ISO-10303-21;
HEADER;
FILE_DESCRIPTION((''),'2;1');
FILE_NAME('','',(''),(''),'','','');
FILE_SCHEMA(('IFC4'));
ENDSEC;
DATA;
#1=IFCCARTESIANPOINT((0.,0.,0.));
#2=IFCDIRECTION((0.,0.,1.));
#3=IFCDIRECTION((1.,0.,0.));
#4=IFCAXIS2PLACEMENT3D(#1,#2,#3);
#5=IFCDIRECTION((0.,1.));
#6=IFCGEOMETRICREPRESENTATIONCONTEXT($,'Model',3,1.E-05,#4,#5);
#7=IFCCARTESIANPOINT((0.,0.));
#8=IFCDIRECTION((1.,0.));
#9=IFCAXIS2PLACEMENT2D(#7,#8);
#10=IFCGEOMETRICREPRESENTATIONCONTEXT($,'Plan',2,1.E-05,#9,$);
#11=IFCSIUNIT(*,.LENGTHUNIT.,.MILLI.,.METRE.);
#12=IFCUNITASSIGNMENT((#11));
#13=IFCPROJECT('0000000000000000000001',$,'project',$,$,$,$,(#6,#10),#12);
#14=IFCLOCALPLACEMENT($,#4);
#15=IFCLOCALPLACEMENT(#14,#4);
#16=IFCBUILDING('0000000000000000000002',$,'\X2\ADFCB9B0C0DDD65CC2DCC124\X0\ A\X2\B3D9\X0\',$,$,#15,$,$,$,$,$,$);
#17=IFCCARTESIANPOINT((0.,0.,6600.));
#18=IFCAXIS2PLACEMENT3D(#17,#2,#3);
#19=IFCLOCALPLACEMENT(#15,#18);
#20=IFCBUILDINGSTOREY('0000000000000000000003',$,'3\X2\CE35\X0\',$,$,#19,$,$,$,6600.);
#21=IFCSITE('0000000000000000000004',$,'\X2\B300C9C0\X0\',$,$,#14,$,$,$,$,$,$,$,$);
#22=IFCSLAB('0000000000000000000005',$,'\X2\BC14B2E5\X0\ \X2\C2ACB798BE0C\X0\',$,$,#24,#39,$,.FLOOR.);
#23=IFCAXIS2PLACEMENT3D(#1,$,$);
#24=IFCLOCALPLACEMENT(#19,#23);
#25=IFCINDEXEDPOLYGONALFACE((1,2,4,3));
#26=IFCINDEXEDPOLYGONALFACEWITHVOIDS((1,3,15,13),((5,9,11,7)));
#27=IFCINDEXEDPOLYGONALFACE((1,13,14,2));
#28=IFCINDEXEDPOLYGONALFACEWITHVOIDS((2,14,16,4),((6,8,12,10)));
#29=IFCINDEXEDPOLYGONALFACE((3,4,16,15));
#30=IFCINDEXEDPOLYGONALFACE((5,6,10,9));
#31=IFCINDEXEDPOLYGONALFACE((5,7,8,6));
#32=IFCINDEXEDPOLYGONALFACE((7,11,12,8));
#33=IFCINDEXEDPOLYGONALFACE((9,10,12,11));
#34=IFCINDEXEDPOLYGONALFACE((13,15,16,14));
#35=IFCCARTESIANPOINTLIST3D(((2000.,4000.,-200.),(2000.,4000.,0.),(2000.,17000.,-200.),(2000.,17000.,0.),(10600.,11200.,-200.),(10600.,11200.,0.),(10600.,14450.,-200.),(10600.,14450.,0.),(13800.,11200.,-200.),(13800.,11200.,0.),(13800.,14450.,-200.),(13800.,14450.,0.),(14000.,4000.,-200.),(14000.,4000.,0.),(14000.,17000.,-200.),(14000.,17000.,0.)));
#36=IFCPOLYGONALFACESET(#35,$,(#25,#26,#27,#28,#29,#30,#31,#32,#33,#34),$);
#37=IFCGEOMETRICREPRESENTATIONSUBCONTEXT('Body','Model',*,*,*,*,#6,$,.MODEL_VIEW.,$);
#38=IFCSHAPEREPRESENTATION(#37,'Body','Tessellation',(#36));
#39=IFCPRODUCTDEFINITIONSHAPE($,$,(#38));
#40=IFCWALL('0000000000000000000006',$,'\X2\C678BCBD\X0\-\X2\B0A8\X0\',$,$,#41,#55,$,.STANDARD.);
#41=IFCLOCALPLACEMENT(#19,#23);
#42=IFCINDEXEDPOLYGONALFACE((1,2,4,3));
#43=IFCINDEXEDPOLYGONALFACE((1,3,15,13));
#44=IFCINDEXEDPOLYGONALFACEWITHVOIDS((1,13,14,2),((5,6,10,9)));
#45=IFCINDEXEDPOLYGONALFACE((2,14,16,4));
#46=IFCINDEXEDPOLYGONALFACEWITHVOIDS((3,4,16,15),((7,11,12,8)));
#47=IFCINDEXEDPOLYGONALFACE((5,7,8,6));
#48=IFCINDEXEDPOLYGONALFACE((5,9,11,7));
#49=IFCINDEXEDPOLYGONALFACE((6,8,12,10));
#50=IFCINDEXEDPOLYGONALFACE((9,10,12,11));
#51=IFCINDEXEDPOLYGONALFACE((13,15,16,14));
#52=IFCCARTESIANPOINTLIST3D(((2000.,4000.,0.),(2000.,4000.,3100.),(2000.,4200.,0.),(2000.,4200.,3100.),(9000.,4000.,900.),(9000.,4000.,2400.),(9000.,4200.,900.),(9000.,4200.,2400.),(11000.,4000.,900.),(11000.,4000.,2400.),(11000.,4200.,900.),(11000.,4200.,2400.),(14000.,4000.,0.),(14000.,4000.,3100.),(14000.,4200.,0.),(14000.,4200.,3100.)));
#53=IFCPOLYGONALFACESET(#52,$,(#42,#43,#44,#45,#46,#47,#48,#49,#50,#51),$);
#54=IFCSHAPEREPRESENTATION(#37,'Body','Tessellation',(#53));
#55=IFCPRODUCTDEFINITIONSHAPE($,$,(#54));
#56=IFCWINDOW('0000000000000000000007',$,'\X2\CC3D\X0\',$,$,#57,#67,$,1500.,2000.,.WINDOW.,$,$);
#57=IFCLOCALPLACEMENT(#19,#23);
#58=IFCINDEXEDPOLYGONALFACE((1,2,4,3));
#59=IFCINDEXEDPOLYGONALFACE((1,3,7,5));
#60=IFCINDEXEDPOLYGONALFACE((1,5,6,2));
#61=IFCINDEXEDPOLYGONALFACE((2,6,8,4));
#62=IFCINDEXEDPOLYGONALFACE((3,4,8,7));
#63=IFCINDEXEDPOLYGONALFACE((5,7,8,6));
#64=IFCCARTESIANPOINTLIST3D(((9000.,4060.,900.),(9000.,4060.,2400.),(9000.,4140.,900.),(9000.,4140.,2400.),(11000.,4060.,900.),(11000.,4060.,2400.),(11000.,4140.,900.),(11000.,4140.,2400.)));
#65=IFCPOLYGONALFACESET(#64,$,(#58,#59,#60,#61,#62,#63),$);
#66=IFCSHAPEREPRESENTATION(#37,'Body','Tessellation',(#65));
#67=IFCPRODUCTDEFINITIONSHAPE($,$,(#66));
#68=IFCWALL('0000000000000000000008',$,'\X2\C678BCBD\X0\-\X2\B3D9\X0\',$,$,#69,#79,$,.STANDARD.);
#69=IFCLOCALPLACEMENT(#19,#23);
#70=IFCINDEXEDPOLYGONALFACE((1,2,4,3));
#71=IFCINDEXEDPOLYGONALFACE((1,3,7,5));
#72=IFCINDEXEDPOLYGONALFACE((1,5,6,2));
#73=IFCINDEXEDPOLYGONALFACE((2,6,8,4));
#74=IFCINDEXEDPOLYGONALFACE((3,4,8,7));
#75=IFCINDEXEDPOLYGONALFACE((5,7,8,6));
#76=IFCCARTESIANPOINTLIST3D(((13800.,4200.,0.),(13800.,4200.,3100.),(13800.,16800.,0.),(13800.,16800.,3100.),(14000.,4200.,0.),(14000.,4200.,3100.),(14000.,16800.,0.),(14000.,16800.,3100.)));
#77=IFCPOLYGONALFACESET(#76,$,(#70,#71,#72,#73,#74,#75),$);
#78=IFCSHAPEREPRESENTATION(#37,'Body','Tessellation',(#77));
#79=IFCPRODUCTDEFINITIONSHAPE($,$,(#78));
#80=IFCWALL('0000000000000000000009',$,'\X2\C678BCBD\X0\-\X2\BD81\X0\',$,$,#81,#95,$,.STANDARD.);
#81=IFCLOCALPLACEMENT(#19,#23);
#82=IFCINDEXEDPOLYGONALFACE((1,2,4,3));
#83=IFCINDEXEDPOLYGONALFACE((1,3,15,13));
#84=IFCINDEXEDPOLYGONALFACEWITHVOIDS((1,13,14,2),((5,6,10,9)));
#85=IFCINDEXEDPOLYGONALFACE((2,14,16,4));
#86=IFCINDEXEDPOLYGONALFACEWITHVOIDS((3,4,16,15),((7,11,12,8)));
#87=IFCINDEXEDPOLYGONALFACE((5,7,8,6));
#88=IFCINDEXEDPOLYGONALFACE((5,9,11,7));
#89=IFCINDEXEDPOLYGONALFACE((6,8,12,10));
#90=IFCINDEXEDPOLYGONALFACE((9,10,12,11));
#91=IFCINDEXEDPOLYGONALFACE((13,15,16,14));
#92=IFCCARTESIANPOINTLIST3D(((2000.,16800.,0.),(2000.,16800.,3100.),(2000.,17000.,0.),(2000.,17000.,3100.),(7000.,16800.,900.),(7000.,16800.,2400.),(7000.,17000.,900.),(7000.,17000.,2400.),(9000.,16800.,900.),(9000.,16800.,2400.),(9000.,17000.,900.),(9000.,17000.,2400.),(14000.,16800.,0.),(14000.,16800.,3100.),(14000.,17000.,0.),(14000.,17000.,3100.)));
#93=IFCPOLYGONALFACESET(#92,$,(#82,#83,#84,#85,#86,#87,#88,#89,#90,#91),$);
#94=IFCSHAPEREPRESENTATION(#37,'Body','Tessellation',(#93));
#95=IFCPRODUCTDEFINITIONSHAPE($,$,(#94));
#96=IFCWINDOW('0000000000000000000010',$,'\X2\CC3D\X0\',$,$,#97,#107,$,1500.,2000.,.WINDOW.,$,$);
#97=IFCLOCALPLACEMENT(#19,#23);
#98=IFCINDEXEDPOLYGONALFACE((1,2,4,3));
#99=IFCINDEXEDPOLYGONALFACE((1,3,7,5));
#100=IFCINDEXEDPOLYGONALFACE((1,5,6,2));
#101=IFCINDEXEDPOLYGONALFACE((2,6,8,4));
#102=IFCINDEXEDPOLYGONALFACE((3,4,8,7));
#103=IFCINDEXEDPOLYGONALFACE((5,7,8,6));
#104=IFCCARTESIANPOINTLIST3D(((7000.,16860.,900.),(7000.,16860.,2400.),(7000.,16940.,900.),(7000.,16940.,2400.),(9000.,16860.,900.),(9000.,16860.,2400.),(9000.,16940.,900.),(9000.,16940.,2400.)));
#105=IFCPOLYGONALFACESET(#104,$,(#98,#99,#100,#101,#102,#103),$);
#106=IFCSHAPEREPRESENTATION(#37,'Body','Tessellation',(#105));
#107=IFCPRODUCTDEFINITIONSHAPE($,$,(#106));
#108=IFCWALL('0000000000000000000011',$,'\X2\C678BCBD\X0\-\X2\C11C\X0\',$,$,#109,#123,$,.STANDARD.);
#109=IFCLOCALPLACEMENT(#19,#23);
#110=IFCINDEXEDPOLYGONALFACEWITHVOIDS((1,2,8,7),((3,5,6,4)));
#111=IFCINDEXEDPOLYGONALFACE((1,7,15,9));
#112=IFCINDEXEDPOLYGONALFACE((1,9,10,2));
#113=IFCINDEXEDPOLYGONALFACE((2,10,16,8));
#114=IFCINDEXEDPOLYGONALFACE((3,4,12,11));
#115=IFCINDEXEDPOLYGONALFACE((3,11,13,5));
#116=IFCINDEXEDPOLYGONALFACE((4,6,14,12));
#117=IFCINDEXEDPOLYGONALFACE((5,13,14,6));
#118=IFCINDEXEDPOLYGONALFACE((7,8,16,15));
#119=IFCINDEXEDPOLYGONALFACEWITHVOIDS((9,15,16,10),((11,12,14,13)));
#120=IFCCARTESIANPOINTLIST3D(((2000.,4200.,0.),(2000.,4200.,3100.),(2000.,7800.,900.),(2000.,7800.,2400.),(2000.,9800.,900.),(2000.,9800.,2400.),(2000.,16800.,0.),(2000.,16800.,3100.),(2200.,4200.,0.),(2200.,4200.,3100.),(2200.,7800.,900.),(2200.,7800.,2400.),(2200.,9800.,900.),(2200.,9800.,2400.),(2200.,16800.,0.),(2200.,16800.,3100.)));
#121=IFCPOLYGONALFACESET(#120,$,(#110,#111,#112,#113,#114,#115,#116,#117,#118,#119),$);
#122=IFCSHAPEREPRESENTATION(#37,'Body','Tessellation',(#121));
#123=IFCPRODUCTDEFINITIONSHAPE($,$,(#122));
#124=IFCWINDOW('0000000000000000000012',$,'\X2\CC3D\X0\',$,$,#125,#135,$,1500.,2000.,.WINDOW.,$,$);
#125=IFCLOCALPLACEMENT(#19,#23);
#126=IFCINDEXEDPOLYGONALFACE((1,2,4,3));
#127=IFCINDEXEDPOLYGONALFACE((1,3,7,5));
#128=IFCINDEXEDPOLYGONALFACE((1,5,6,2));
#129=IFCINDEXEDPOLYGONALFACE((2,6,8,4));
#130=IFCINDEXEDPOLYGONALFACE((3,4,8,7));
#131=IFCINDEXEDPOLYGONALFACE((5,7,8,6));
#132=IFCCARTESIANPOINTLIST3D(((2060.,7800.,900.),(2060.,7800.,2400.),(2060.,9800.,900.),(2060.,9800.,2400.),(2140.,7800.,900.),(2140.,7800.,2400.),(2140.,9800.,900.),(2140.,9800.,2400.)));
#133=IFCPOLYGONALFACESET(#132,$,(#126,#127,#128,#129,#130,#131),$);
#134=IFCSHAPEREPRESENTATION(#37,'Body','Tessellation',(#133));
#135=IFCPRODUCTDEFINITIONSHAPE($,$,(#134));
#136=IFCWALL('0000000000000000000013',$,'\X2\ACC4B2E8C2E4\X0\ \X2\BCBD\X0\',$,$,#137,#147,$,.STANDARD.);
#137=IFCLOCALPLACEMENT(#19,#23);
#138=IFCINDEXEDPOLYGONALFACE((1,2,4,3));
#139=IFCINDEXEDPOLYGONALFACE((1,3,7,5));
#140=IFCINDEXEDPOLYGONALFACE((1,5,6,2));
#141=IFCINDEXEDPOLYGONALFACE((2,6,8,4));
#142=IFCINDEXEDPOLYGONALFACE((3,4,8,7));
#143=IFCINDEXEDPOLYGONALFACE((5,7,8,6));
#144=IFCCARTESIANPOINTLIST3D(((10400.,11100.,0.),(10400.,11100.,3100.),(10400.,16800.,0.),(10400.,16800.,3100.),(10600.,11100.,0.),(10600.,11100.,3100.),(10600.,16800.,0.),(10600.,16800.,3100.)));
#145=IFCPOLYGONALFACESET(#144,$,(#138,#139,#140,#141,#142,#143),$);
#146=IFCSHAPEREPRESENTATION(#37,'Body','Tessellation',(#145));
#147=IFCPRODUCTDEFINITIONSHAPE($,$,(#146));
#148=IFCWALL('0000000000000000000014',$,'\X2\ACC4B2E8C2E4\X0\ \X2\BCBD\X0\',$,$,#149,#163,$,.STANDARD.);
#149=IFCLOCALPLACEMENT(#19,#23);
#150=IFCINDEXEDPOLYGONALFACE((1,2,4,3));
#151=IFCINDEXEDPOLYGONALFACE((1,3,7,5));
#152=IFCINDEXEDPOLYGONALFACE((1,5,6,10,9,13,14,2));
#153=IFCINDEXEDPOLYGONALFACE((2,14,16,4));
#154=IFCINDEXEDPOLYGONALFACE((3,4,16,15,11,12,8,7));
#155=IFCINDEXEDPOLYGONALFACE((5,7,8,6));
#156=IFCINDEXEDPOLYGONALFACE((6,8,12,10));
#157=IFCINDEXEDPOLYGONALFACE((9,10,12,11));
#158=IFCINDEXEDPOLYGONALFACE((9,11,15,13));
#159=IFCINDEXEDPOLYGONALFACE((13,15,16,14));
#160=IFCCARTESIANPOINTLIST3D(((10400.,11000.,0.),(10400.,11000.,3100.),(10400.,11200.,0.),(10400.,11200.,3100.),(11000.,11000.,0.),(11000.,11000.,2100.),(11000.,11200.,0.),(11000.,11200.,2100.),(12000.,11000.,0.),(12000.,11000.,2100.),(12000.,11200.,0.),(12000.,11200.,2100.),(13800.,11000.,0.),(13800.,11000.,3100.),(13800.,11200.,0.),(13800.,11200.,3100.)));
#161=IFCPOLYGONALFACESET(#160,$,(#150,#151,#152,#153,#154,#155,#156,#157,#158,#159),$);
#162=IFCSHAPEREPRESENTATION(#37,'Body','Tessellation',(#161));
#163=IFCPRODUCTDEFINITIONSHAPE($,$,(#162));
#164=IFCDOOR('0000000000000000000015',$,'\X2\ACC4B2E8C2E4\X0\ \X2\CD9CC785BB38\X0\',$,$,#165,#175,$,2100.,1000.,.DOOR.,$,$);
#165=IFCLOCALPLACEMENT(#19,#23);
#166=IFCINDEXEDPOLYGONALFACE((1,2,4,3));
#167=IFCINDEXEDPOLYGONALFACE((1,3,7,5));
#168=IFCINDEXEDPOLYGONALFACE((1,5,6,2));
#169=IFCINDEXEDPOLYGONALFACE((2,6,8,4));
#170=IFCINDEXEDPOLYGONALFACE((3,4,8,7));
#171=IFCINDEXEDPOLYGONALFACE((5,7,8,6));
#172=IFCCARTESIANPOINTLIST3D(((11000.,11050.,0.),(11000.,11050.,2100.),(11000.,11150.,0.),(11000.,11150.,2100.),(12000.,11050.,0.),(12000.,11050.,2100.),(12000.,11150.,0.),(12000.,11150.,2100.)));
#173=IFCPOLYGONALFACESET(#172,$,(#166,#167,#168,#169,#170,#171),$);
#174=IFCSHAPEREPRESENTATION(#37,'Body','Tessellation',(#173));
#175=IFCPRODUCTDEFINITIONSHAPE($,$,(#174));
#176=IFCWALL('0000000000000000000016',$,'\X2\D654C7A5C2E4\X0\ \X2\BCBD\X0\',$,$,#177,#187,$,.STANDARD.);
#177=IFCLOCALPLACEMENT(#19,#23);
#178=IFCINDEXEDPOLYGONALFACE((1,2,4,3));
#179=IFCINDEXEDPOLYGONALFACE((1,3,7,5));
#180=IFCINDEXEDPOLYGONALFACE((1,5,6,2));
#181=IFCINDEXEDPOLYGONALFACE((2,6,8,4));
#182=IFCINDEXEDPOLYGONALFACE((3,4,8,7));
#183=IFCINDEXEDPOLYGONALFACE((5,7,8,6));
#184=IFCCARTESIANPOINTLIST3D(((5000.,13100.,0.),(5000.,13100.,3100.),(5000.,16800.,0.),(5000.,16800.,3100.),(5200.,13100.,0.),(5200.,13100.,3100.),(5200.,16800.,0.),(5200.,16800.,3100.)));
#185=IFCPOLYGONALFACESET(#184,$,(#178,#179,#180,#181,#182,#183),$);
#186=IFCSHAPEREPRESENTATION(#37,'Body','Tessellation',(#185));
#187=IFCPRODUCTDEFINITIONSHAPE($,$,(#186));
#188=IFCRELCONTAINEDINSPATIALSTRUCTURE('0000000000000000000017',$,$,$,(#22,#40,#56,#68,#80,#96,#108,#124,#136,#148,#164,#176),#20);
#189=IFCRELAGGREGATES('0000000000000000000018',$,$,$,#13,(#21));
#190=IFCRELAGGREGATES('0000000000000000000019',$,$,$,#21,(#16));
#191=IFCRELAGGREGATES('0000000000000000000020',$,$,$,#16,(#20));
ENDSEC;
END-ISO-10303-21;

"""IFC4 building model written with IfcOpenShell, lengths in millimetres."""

from ifc_helpers import new_model, si_unit, direction, frame, origin_with_axes, origin_2d_with_axis, place, context, subcontext, project, spatial, polyline, outline, extrude, element, fill, save


model = new_model("IFC4")

# Units and contexts
model_context = context("Model", 3, precision=1e-05, world=origin_with_axes(), true_north=direction((0.0, 1.0)))
plan_context = context("Plan", 2, precision=1e-05, world=origin_2d_with_axis())
body_context = subcontext(model_context, "Body", "Model", "MODEL_VIEW")
ifc_project = project(units=[si_unit("LENGTHUNIT", "METRE", prefix="MILLI")], contexts=[model_context, plan_context])

# Site, building, storey
site_placement = place(None, origin_with_axes())
site = spatial("IfcSite", under=ifc_project, at=site_placement, Name="대지")
building_placement = place(site_placement, origin_with_axes())
building = spatial("IfcBuilding", under=site, at=building_placement, Name="근린생활시설 A동")
storey_placement = place(building_placement, frame((0.0, 0.0, 6600.0), z_axis=(0.0, 0.0, 1.0), x_axis=(1.0, 0.0, 0.0)))
storey = spatial("IfcBuildingStorey", under=building, at=storey_placement, Name="3층", Elevation=6600.0)

# Slab
slab_placement = place(storey_placement, origin_with_axes())
element("IfcSlab", 1, at=slab_placement, inside=storey, Name="바닥 슬래브", PredefinedType="FLOOR", context=body_context, shape_type="SweptSolid", body=[
    extrude(outline(polyline([(2000.0, 4000.0), (14000.0, 4000.0), (14000.0, 17000.0), (2000.0, 17000.0), (2000.0, 4000.0)]), holes=[polyline([(10600.0, 11200.0), (13800.0, 11200.0), (13800.0, 14450.0), (10600.0, 14450.0), (10600.0, 11200.0)])]), frame((0.0, 0.0, -200.0), z_axis=(0.0, 0.0, 1.0), x_axis=(1.0, 0.0, 0.0)), (0.0, 0.0, 1.0), 200.0),
])

# Wall, opening, window
wall_1_placement = place(storey_placement, origin_with_axes())
wall_1 = element("IfcWall", 2, at=wall_1_placement, inside=storey, Name="외벽-남", PredefinedType="STANDARD", context=body_context, shape_type="SweptSolid", body=[
    extrude(outline(polyline([(2000.0, 4200.0), (14000.0, 4200.0), (14000.0, 4000.0), (2000.0, 4000.0), (2000.0, 4200.0)])), origin_with_axes(), (0.0, 0.0, 1.0), 3100.0),
])
opening_1_placement = place(storey_placement, origin_with_axes())
opening_1 = element("IfcOpeningElement", 3, at=opening_1_placement, cuts=wall_1, PredefinedType="OPENING", context=body_context, shape_type="SweptSolid", body=[
    extrude(outline(polyline([(9000.0, 3950.0), (11000.0, 3950.0), (11000.0, 4250.0), (9000.0, 4250.0), (9000.0, 3950.0)])), frame((0.0, 0.0, 900.0), z_axis=(0.0, 0.0, 1.0), x_axis=(1.0, 0.0, 0.0)), (0.0, 0.0, 1.0), 1500.0),
])
window_1_placement = place(storey_placement, origin_with_axes())
window_1 = element("IfcWindow", 4, at=window_1_placement, inside=storey, Name="창", OverallHeight=1500.0, OverallWidth=2000.0, PredefinedType="WINDOW", context=body_context, shape_type="SweptSolid", body=[
    extrude(outline(polyline([(9000.0, 4060.0), (11000.0, 4060.0), (11000.0, 4140.0), (9000.0, 4140.0), (9000.0, 4060.0)])), frame((0.0, 0.0, 900.0), z_axis=(0.0, 0.0, 1.0), x_axis=(1.0, 0.0, 0.0)), (0.0, 0.0, 1.0), 1500.0),
])
fill(opening_1, window_1)

# Wall
wall_2_placement = place(storey_placement, origin_with_axes())
element("IfcWall", 5, at=wall_2_placement, inside=storey, Name="외벽-동", PredefinedType="STANDARD", context=body_context, shape_type="SweptSolid", body=[
    extrude(outline(polyline([(13800.0, 4200.0), (13800.0, 16800.0), (14000.0, 16800.0), (14000.0, 4200.0), (13800.0, 4200.0)])), origin_with_axes(), (0.0, 0.0, 1.0), 3100.0),
])

# Walls, openings, windows
wall_3_placement = place(storey_placement, origin_with_axes())
wall_3 = element("IfcWall", 6, at=wall_3_placement, inside=storey, Name="외벽-북", PredefinedType="STANDARD", context=body_context, shape_type="SweptSolid", body=[
    extrude(outline(polyline([(14000.0, 16800.0), (2000.0, 16800.0), (2000.0, 17000.0), (14000.0, 17000.0), (14000.0, 16800.0)])), origin_with_axes(), (0.0, 0.0, 1.0), 3100.0),
])
opening_2_placement = place(storey_placement, origin_with_axes())
opening_2 = element("IfcOpeningElement", 7, at=opening_2_placement, cuts=wall_3, PredefinedType="OPENING", context=body_context, shape_type="SweptSolid", body=[
    extrude(outline(polyline([(9000.0, 17050.0), (7000.0, 17050.0), (7000.0, 16750.0), (9000.0, 16750.0), (9000.0, 17050.0)])), frame((0.0, 0.0, 900.0), z_axis=(0.0, 0.0, 1.0), x_axis=(1.0, 0.0, 0.0)), (0.0, 0.0, 1.0), 1500.0),
])
window_2_placement = place(storey_placement, origin_with_axes())
window_2 = element("IfcWindow", 8, at=window_2_placement, inside=storey, Name="창", OverallHeight=1500.0, OverallWidth=2000.0, PredefinedType="WINDOW", context=body_context, shape_type="SweptSolid", body=[
    extrude(outline(polyline([(9000.0, 16940.0), (7000.0, 16940.0), (7000.0, 16860.0), (9000.0, 16860.0), (9000.0, 16940.0)])), frame((0.0, 0.0, 900.0), z_axis=(0.0, 0.0, 1.0), x_axis=(1.0, 0.0, 0.0)), (0.0, 0.0, 1.0), 1500.0),
])
fill(opening_2, window_2)
wall_4_placement = place(storey_placement, origin_with_axes())
wall_4 = element("IfcWall", 9, at=wall_4_placement, inside=storey, Name="외벽-서", PredefinedType="STANDARD", context=body_context, shape_type="SweptSolid", body=[
    extrude(outline(polyline([(2200.0, 16800.0), (2200.0, 4200.0), (2000.0, 4200.0), (2000.0, 16800.0), (2200.0, 16800.0)])), origin_with_axes(), (0.0, 0.0, 1.0), 3100.0),
])
opening_3_placement = place(storey_placement, origin_with_axes())
opening_3 = element("IfcOpeningElement", 10, at=opening_3_placement, cuts=wall_4, PredefinedType="OPENING", context=body_context, shape_type="SweptSolid", body=[
    extrude(outline(polyline([(1950.0, 9800.0), (1950.0, 7800.0), (2250.0, 7800.0), (2250.0, 9800.0), (1950.0, 9800.0)])), frame((0.0, 0.0, 900.0), z_axis=(0.0, 0.0, 1.0), x_axis=(1.0, 0.0, 0.0)), (0.0, 0.0, 1.0), 1500.0),
])
window_3_placement = place(storey_placement, origin_with_axes())
window_3 = element("IfcWindow", 11, at=window_3_placement, inside=storey, Name="창", OverallHeight=1500.0, OverallWidth=2000.0, PredefinedType="WINDOW", context=body_context, shape_type="SweptSolid", body=[
    extrude(outline(polyline([(2060.0, 9800.0), (2060.0, 7800.0), (2140.0, 7800.0), (2140.0, 9800.0), (2060.0, 9800.0)])), frame((0.0, 0.0, 900.0), z_axis=(0.0, 0.0, 1.0), x_axis=(1.0, 0.0, 0.0)), (0.0, 0.0, 1.0), 1500.0),
])
fill(opening_3, window_3)

# Wall
wall_5_placement = place(storey_placement, origin_with_axes())
element("IfcWall", 12, at=wall_5_placement, inside=storey, Name="계단실 벽", PredefinedType="STANDARD", context=body_context, shape_type="SweptSolid", body=[
    extrude(outline(polyline([(10400.0, 11100.0), (10400.0, 16800.0), (10600.0, 16800.0), (10600.0, 11100.0), (10400.0, 11100.0)])), origin_with_axes(), (0.0, 0.0, 1.0), 3100.0),
])

# Wall, opening, door
wall_6_placement = place(storey_placement, origin_with_axes())
wall_6 = element("IfcWall", 13, at=wall_6_placement, inside=storey, Name="계단실 벽", PredefinedType="STANDARD", context=body_context, shape_type="SweptSolid", body=[
    extrude(outline(polyline([(10400.0, 11200.0), (13800.0, 11200.0), (13800.0, 11000.0), (10400.0, 11000.0), (10400.0, 11200.0)])), origin_with_axes(), (0.0, 0.0, 1.0), 3100.0),
])
opening_4_placement = place(storey_placement, origin_with_axes())
opening_4 = element("IfcOpeningElement", 14, at=opening_4_placement, cuts=wall_6, PredefinedType="OPENING", context=body_context, shape_type="SweptSolid", body=[
    extrude(outline(polyline([(11000.0, 10950.0), (12000.0, 10950.0), (12000.0, 11250.0), (11000.0, 11250.0), (11000.0, 10950.0)])), origin_with_axes(), (0.0, 0.0, 1.0), 2100.0),
])
door_1_placement = place(storey_placement, origin_with_axes())
door_1 = element("IfcDoor", 15, at=door_1_placement, inside=storey, Name="계단실 출입문", OverallHeight=2100.0, OverallWidth=1000.0, PredefinedType="DOOR", context=body_context, shape_type="SweptSolid", body=[
    extrude(outline(polyline([(11000.0, 11050.0), (12000.0, 11050.0), (12000.0, 11150.0), (11000.0, 11150.0), (11000.0, 11050.0)])), origin_with_axes(), (0.0, 0.0, 1.0), 2100.0),
])
fill(opening_4, door_1)

# Wall
wall_7_placement = place(storey_placement, origin_with_axes())
element("IfcWall", 16, at=wall_7_placement, inside=storey, Name="화장실 벽", PredefinedType="STANDARD", context=body_context, shape_type="SweptSolid", body=[
    extrude(outline(polyline([(5000.0, 13100.0), (5000.0, 16800.0), (5200.0, 16800.0), (5200.0, 13100.0), (5000.0, 13100.0)])), origin_with_axes(), (0.0, 0.0, 1.0), 3100.0),
])

save(model, "model.ifc")
